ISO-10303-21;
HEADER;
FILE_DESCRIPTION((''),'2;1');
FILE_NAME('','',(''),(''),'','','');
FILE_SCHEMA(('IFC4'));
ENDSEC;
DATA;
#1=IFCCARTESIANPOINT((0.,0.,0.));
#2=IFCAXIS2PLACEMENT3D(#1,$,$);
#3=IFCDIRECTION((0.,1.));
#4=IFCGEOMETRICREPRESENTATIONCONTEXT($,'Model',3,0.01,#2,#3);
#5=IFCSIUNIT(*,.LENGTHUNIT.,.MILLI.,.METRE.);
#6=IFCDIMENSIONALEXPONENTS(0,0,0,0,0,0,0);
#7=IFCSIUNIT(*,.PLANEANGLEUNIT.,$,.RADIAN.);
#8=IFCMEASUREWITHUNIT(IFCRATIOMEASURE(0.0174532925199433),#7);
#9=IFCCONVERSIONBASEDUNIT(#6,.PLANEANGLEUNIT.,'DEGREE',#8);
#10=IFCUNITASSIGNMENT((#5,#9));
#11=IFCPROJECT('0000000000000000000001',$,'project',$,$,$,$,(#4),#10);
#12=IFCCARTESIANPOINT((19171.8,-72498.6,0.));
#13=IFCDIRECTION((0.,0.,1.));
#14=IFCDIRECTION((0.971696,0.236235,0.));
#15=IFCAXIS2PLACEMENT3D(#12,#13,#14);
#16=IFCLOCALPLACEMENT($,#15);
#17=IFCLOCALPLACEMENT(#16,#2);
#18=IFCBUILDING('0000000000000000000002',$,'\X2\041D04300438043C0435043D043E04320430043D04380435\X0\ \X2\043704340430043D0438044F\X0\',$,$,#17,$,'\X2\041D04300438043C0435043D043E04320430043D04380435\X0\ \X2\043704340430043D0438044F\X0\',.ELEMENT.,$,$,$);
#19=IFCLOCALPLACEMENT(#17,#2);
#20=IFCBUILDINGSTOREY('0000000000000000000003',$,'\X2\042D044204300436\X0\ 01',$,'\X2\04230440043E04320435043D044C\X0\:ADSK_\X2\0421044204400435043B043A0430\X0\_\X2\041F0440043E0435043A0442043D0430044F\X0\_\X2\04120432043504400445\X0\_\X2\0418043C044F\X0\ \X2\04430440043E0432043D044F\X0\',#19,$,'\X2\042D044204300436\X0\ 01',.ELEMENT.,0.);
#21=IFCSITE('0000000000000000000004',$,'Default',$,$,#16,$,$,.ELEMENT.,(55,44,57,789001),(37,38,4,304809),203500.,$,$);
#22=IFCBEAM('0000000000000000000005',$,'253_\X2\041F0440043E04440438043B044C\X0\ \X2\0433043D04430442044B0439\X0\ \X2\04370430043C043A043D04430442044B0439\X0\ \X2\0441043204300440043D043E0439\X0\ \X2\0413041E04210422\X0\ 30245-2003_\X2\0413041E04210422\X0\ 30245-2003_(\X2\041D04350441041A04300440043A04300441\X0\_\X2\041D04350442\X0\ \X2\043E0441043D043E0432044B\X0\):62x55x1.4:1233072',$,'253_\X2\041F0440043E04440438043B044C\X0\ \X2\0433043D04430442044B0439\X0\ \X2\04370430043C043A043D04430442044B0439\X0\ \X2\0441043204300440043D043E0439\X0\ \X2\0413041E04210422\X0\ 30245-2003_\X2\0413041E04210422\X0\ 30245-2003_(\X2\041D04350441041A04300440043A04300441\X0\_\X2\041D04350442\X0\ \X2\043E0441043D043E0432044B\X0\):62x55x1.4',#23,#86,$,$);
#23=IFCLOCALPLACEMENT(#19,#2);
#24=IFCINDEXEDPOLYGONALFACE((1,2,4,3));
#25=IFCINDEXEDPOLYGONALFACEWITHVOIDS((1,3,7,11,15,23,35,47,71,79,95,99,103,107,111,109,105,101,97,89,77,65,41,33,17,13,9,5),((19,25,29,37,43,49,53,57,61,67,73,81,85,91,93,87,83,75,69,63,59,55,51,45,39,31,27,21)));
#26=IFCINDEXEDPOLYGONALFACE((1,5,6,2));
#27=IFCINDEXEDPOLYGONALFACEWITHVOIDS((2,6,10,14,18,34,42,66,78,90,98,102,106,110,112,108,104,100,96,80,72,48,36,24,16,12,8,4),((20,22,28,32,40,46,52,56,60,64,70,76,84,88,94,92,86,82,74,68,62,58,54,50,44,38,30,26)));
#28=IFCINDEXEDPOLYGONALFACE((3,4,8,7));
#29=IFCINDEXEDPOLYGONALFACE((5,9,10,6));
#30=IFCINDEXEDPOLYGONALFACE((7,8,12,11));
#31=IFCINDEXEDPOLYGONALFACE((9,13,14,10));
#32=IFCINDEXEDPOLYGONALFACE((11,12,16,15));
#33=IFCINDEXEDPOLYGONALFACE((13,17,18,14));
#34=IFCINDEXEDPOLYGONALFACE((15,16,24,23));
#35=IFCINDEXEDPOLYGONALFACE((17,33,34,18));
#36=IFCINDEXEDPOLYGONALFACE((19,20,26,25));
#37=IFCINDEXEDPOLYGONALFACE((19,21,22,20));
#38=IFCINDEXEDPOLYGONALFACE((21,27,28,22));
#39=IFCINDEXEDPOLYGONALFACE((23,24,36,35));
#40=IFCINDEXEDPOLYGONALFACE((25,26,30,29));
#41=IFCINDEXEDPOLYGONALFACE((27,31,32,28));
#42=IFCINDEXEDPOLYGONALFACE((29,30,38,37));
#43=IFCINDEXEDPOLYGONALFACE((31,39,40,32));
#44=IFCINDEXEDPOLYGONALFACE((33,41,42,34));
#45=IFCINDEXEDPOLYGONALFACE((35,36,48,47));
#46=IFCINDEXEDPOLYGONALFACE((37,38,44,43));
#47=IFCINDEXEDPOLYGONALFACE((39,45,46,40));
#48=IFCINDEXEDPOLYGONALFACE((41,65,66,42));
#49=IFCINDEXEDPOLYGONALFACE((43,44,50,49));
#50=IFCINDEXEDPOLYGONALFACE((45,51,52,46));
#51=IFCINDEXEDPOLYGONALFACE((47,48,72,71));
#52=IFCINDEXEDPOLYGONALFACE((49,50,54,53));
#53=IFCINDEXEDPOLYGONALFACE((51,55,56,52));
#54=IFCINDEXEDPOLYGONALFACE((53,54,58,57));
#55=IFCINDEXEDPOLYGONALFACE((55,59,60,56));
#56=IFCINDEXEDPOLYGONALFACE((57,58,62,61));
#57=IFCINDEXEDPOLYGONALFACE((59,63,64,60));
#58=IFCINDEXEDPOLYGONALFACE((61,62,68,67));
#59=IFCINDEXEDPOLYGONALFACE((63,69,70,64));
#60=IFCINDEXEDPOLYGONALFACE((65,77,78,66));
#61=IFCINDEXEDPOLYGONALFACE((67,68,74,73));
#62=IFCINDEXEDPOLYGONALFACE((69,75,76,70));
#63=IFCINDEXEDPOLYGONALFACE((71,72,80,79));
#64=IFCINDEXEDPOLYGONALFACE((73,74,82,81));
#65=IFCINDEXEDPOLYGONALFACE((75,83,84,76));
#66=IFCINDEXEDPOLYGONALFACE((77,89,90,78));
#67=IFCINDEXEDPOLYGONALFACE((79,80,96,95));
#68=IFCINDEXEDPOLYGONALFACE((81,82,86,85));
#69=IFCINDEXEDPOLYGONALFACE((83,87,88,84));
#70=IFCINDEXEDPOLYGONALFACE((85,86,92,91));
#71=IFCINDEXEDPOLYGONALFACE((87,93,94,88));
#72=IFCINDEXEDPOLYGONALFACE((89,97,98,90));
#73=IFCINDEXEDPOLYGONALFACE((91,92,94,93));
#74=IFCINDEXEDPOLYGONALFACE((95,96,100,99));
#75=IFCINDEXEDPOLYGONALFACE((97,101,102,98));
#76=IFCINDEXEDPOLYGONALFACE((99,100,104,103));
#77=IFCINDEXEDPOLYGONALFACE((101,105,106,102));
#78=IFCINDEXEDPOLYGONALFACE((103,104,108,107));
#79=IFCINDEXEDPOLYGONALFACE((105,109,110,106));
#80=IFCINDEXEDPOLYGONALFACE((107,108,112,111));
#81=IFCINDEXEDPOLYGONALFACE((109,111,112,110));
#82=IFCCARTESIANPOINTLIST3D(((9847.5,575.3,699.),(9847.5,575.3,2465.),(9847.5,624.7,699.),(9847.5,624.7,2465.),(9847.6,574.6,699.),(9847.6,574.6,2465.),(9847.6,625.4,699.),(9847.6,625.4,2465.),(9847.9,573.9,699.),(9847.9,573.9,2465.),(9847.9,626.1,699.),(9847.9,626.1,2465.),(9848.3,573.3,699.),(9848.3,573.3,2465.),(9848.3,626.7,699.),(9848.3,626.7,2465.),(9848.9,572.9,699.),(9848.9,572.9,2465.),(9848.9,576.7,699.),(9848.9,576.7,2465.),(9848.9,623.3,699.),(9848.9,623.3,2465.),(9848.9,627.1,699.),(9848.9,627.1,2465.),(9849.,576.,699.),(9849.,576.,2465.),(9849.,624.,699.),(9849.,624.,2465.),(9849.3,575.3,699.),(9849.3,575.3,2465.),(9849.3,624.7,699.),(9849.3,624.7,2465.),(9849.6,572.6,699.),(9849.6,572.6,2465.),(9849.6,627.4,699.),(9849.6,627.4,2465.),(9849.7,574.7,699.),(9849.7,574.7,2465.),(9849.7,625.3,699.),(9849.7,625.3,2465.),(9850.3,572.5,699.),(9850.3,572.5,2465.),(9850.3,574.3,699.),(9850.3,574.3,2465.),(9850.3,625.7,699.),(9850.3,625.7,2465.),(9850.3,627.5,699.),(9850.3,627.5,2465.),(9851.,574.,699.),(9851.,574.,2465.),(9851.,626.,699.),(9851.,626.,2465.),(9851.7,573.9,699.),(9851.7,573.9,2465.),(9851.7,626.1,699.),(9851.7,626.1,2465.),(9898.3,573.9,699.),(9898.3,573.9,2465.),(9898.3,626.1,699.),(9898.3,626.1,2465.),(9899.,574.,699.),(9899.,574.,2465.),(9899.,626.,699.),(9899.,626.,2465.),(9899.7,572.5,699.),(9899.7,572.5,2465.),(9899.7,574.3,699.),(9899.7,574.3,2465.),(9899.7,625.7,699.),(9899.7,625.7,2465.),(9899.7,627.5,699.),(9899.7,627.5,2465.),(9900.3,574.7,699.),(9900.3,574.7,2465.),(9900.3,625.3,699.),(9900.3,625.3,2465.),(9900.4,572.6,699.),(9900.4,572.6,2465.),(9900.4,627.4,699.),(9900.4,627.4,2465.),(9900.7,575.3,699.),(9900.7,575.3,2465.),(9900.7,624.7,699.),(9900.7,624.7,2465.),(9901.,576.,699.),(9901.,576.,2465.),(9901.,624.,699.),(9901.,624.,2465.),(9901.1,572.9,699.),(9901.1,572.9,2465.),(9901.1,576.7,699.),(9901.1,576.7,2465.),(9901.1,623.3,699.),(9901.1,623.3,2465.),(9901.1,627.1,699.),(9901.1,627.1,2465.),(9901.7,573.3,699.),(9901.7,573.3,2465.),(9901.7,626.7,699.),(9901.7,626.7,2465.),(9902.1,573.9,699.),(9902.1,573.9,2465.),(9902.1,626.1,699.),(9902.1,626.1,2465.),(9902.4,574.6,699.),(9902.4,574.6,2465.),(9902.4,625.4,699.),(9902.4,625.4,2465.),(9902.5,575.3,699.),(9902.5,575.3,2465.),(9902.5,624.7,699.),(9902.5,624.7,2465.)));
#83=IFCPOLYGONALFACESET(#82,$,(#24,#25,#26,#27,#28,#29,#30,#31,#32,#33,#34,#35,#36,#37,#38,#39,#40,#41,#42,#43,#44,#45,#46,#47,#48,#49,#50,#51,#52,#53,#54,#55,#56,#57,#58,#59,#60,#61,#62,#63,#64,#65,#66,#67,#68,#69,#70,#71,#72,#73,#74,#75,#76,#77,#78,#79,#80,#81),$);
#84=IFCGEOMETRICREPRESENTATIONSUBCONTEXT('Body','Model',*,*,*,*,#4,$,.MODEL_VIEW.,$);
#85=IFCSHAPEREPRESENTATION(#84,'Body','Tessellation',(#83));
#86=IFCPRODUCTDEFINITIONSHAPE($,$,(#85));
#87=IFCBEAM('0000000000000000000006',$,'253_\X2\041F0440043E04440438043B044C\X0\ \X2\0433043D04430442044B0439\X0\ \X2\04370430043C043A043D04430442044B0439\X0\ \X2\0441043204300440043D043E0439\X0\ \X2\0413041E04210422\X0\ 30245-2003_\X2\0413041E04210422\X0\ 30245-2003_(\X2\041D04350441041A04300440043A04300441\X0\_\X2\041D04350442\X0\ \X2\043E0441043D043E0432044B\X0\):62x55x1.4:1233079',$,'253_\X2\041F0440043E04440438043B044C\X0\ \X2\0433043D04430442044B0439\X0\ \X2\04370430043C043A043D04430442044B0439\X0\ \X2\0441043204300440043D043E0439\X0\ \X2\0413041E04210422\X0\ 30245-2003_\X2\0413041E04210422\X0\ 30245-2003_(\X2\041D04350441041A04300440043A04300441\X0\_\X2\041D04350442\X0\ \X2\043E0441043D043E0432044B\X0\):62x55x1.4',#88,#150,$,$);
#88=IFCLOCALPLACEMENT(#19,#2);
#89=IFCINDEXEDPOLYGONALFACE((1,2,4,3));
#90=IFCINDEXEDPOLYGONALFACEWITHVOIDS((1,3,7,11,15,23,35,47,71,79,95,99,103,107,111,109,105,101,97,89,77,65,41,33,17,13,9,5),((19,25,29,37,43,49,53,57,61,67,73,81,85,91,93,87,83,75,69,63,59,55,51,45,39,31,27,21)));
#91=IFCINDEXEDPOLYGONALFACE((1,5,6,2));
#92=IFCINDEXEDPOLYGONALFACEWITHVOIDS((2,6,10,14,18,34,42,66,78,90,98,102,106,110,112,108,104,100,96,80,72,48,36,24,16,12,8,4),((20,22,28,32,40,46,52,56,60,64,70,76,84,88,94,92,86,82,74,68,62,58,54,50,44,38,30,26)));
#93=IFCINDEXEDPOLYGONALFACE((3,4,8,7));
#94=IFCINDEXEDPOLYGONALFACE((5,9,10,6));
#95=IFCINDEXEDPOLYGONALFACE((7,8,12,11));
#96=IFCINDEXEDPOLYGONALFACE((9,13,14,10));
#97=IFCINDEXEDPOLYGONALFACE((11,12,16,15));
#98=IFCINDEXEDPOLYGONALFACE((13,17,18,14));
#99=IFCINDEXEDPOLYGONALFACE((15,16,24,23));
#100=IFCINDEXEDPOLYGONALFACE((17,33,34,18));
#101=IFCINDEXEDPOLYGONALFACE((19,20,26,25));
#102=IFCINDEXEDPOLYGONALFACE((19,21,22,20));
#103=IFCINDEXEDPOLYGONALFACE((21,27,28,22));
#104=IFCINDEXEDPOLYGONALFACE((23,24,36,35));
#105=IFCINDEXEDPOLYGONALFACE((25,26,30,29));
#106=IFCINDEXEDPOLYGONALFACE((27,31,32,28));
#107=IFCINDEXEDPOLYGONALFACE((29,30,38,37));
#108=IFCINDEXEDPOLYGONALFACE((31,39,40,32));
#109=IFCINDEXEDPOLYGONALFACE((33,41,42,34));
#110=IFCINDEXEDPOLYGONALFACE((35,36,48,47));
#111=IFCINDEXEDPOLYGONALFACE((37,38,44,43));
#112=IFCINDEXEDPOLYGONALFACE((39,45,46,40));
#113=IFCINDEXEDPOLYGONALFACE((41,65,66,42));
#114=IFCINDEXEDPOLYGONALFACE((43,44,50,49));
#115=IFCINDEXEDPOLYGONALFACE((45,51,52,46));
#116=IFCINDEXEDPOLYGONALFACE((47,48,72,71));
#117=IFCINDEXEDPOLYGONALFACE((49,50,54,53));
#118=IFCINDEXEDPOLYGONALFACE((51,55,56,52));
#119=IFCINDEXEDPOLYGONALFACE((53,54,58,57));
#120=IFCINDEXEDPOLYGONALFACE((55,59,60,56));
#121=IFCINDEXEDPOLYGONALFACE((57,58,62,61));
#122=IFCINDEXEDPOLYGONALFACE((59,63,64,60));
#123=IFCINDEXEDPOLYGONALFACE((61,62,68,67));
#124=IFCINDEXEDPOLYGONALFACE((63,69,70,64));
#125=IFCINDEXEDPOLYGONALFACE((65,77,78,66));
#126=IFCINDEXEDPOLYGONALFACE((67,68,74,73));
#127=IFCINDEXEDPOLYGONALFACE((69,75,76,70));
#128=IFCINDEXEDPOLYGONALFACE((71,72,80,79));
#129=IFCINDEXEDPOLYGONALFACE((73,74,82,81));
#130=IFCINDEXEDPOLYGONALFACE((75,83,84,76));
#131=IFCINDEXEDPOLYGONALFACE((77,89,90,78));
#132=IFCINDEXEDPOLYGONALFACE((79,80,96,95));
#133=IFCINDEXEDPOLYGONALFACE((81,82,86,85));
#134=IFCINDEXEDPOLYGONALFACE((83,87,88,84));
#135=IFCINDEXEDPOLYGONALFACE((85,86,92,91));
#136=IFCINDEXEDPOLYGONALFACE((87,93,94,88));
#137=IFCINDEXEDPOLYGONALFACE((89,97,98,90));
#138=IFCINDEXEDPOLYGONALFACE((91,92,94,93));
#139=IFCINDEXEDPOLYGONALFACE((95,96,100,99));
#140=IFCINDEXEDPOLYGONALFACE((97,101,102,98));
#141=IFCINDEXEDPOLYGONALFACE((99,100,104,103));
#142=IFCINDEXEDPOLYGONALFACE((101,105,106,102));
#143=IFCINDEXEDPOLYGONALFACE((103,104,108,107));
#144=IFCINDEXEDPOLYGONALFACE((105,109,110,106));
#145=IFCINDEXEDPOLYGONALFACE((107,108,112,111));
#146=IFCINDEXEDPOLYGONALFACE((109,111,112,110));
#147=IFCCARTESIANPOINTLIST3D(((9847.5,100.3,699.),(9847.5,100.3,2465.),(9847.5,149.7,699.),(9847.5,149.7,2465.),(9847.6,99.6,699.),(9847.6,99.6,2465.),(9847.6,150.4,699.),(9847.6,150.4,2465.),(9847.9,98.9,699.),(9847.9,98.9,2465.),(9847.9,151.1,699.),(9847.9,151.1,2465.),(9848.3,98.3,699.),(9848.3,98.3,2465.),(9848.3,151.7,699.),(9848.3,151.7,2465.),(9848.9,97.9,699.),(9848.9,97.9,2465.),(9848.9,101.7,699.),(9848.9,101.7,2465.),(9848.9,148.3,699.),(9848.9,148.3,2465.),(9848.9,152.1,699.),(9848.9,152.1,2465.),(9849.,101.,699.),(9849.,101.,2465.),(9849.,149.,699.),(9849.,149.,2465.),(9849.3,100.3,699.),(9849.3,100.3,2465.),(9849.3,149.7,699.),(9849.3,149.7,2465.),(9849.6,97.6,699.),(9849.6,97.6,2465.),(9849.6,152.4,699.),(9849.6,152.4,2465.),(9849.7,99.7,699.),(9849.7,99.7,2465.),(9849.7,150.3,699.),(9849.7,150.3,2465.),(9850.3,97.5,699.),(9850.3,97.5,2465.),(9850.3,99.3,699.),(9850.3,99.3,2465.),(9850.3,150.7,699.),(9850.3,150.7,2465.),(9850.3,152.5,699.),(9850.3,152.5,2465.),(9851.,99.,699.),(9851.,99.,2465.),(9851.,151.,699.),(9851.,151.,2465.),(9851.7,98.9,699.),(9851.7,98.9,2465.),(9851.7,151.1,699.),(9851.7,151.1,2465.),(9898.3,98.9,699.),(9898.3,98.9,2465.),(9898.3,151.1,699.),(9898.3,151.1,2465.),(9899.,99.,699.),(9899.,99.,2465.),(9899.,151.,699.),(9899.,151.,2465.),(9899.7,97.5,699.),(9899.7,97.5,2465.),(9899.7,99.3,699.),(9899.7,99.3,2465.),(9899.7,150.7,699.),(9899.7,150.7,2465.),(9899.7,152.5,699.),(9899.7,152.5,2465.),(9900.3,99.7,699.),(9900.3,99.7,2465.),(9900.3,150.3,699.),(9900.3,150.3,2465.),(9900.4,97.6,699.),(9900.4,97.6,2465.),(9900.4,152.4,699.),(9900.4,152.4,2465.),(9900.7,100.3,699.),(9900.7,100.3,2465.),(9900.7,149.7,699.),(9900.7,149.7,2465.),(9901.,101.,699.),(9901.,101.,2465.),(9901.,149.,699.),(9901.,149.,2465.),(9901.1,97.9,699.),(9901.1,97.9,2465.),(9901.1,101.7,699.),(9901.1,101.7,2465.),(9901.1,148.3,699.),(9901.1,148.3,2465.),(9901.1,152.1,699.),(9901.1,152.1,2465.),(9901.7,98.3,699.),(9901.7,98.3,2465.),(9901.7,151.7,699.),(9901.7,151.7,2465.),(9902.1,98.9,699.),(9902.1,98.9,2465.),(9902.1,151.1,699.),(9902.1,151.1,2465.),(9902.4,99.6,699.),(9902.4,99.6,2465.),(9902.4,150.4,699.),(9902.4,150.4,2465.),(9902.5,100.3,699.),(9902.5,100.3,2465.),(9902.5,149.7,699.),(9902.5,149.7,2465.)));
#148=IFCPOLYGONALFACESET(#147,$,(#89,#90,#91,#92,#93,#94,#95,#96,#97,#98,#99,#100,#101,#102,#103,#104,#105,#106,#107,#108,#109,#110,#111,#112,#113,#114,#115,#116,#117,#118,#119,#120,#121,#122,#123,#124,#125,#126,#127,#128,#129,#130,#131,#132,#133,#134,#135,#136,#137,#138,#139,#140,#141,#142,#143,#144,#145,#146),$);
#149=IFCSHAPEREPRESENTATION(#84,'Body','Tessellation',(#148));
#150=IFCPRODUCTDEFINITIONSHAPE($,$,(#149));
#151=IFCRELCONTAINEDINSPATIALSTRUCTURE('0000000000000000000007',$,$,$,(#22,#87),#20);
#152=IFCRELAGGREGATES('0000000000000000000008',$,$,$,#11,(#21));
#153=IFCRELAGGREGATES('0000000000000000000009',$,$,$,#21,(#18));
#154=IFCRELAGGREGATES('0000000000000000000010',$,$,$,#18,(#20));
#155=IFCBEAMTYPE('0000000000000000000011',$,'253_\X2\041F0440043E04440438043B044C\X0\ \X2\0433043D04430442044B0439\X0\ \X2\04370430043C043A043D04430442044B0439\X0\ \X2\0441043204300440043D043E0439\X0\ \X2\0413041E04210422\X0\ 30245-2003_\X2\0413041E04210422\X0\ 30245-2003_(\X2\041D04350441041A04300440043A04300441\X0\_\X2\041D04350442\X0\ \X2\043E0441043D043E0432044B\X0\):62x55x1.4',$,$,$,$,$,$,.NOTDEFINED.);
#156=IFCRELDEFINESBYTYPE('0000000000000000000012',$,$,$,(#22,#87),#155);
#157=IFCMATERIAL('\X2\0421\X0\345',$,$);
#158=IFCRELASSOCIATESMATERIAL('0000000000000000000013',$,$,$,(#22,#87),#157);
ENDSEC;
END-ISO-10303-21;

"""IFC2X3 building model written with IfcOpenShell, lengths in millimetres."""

from ifc_helpers import new_model, entity, si_unit, converted_unit, direction, frame, frame_2d, origin, place, context, subcontext, project, spatial, polyline, circle_curve, parameter, trimmed, segment, composite_curve, outline, extrude, material, type_object, element, save


model = new_model("IFC2X3")

# Units and contexts
model_context = context("Model", 3, precision=0.01, world=origin(), true_north=direction((0.0, 1.0)))
body_context = subcontext(model_context, "Body", "Model", "MODEL_VIEW")
ifc_project = project(units=[si_unit("LENGTHUNIT", "METRE", prefix="MILLI"), converted_unit("PLANEANGLEUNIT", "DEGREE", entity("IfcRatioMeasure", 0.0174532925199433), si_unit("PLANEANGLEUNIT", "RADIAN"), dimensions=[0, 0, 0, 0, 0, 0, 0])], contexts=[model_context])

# Site, building, storey
site_placement = place(None, frame((19171.8, -72498.6, 0.0), z_axis=(0.0, 0.0, 1.0), x_axis=(0.971696, 0.236235, 0.0)))
site = spatial("IfcSite", under=ifc_project, at=site_placement, Name="Default", CompositionType="ELEMENT", RefLatitude=(55, 44, 57, 789001), RefLongitude=(37, 38, 4, 304809), RefElevation=203500.0)
building_placement = place(site_placement, origin())
building = spatial("IfcBuilding", under=site, at=building_placement, Name="Наименование здания", LongName="Наименование здания", CompositionType="ELEMENT")
storey_placement = place(building_placement, origin())
storey = spatial("IfcBuildingStorey", under=building, at=storey_placement, Name="Этаж 01", ObjectType="Уровень:ADSK_Стрелка_Проектная_Вверх_Имя уровня", LongName="Этаж 01", CompositionType="ELEMENT", Elevation=0.0)

# Beams
ifc_material_1 = material(Name="С345")
beam_type_1 = type_object("IfcBeamType", Name="253_Профиль гнутый замкнутый сварной ГОСТ 30245-2003_ГОСТ 30245-2003_(НесКаркас_Нет основы):62x55x1.4", PredefinedType="NOTDEFINED")
beam_1_placement = place(storey_placement, frame((9845.9, 570.9, 699.0), z_axis=(1.0, 0.0, 0.0), x_axis=(0.0, 0.0, 1.0)))
element("IfcBeam", 1, at=beam_1_placement, inside=storey, type_object=beam_type_1, material=ifc_material_1, Name="253_Профиль гнутый замкнутый сварной ГОСТ 30245-2003_ГОСТ 30245-2003_(НесКаркас_Нет основы):62x55x1.4:1233072", ObjectType="253_Профиль гнутый замкнутый сварной ГОСТ 30245-2003_ГОСТ 30245-2003_(НесКаркас_Нет основы):62x55x1.4", context=body_context, shape_type="SweptSolid", body=[
    extrude(outline(composite_curve([segment(trimmed(circle_curve(frame_2d((24.7, -24.7), x_axis=(1.0, 0.0)), 2.8), [parameter(270.0)], [parameter(0.0)], True, "PARAMETER"), True, "CONTINUOUS"), segment(polyline([(27.5, -24.7), (27.5, 24.7)]), True, "CONTINUOUS"), segment(trimmed(circle_curve(frame_2d((24.7, 24.7), x_axis=(1.0, 0.0)), 2.8), [parameter(0.0)], [parameter(90.0)], True, "PARAMETER"), True, "CONTINUOUS"), segment(polyline([(24.7, 27.5), (-24.7, 27.5)]), True, "CONTINUOUS"), segment(trimmed(circle_curve(frame_2d((-24.7, 24.7), x_axis=(1.0, 0.0)), 2.8), [parameter(90.0)], [parameter(180.0)], True, "PARAMETER"), True, "CONTINUOUS"), segment(polyline([(-27.5, 24.7), (-27.5, -24.7)]), True, "CONTINUOUS"), segment(trimmed(circle_curve(frame_2d((-24.7, -24.7), x_axis=(1.0, 0.0)), 2.8), [parameter(180.0)], [parameter(270.0)], True, "PARAMETER"), True, "CONTINUOUS"), segment(polyline([(-24.7, -27.5), (24.7, -27.5)]), True, "CONTINUOUS")], self_intersect=False), holes=[composite_curve([segment(polyline([(23.3, -26.1), (-23.3, -26.1)]), True, "CONTINUOUS"), segment(trimmed(circle_curve(frame_2d((-23.3, -23.3), x_axis=(1.0, 0.0)), 2.8), [parameter(180.0)], [parameter(270.0)], True, "PARAMETER"), False, "CONTINUOUS"), segment(polyline([(-26.1, -23.3), (-26.1, 23.3)]), True, "CONTINUOUS"), segment(trimmed(circle_curve(frame_2d((-23.3, 23.3), x_axis=(1.0, 0.0)), 2.8), [parameter(90.0)], [parameter(180.0)], True, "PARAMETER"), False, "CONTINUOUS"), segment(polyline([(-23.3, 26.1), (23.3, 26.1)]), True, "CONTINUOUS"), segment(trimmed(circle_curve(frame_2d((23.3, 23.3), x_axis=(1.0, 0.0)), 2.8), [parameter(0.0)], [parameter(90.0)], True, "PARAMETER"), False, "CONTINUOUS"), segment(polyline([(26.1, 23.3), (26.1, -23.3)]), True, "CONTINUOUS"), segment(trimmed(circle_curve(frame_2d((23.3, -23.3), x_axis=(1.0, 0.0)), 2.8), [parameter(270.0)], [parameter(0.0)], True, "PARAMETER"), False, "CONTINUOUS")], self_intersect=False)]), frame((0.0, -29.1, 29.1), z_axis=(1.0, 0.0, 0.0), x_axis=(0.0, -1.0, 0.0)), (0.0, 0.0, 1.0), 1766.0),
])
beam_2_placement = place(storey_placement, frame((9845.9, 95.9, 699.0), z_axis=(1.0, 0.0, 0.0), x_axis=(0.0, 0.0, 1.0)))
element("IfcBeam", 2, at=beam_2_placement, inside=storey, type_object=beam_type_1, material=ifc_material_1, Name="253_Профиль гнутый замкнутый сварной ГОСТ 30245-2003_ГОСТ 30245-2003_(НесКаркас_Нет основы):62x55x1.4:1233079", ObjectType="253_Профиль гнутый замкнутый сварной ГОСТ 30245-2003_ГОСТ 30245-2003_(НесКаркас_Нет основы):62x55x1.4", context=body_context, shape_type="SweptSolid", body=[
    extrude(outline(composite_curve([segment(trimmed(circle_curve(frame_2d((24.7, -24.7), x_axis=(1.0, 0.0)), 2.8), [parameter(270.0)], [parameter(0.0)], True, "PARAMETER"), True, "CONTINUOUS"), segment(polyline([(27.5, -24.7), (27.5, 24.7)]), True, "CONTINUOUS"), segment(trimmed(circle_curve(frame_2d((24.7, 24.7), x_axis=(1.0, 0.0)), 2.8), [parameter(0.0)], [parameter(90.0)], True, "PARAMETER"), True, "CONTINUOUS"), segment(polyline([(24.7, 27.5), (-24.7, 27.5)]), True, "CONTINUOUS"), segment(trimmed(circle_curve(frame_2d((-24.7, 24.7), x_axis=(1.0, 0.0)), 2.8), [parameter(90.0)], [parameter(180.0)], True, "PARAMETER"), True, "CONTINUOUS"), segment(polyline([(-27.5, 24.7), (-27.5, -24.7)]), True, "CONTINUOUS"), segment(trimmed(circle_curve(frame_2d((-24.7, -24.7), x_axis=(1.0, 0.0)), 2.8), [parameter(180.0)], [parameter(270.0)], True, "PARAMETER"), True, "CONTINUOUS"), segment(polyline([(-24.7, -27.5), (24.7, -27.5)]), True, "CONTINUOUS")], self_intersect=False), holes=[composite_curve([segment(polyline([(23.3, -26.1), (-23.3, -26.1)]), True, "CONTINUOUS"), segment(trimmed(circle_curve(frame_2d((-23.3, -23.3), x_axis=(1.0, 0.0)), 2.8), [parameter(180.0)], [parameter(270.0)], True, "PARAMETER"), False, "CONTINUOUS"), segment(polyline([(-26.1, -23.3), (-26.1, 23.3)]), True, "CONTINUOUS"), segment(trimmed(circle_curve(frame_2d((-23.3, 23.3), x_axis=(1.0, 0.0)), 2.8), [parameter(90.0)], [parameter(180.0)], True, "PARAMETER"), False, "CONTINUOUS"), segment(polyline([(-23.3, 26.1), (23.3, 26.1)]), True, "CONTINUOUS"), segment(trimmed(circle_curve(frame_2d((23.3, 23.3), x_axis=(1.0, 0.0)), 2.8), [parameter(0.0)], [parameter(90.0)], True, "PARAMETER"), False, "CONTINUOUS"), segment(polyline([(26.1, 23.3), (26.1, -23.3)]), True, "CONTINUOUS"), segment(trimmed(circle_curve(frame_2d((23.3, -23.3), x_axis=(1.0, 0.0)), 2.8), [parameter(270.0)], [parameter(0.0)], True, "PARAMETER"), False, "CONTINUOUS")], self_intersect=False)]), frame((0.0, -29.1, 29.1), z_axis=(1.0, 0.0, 0.0), x_axis=(0.0, -1.0, 0.0)), (0.0, 0.0, 1.0), 1766.0),
])

save(model, "model.ifc")
